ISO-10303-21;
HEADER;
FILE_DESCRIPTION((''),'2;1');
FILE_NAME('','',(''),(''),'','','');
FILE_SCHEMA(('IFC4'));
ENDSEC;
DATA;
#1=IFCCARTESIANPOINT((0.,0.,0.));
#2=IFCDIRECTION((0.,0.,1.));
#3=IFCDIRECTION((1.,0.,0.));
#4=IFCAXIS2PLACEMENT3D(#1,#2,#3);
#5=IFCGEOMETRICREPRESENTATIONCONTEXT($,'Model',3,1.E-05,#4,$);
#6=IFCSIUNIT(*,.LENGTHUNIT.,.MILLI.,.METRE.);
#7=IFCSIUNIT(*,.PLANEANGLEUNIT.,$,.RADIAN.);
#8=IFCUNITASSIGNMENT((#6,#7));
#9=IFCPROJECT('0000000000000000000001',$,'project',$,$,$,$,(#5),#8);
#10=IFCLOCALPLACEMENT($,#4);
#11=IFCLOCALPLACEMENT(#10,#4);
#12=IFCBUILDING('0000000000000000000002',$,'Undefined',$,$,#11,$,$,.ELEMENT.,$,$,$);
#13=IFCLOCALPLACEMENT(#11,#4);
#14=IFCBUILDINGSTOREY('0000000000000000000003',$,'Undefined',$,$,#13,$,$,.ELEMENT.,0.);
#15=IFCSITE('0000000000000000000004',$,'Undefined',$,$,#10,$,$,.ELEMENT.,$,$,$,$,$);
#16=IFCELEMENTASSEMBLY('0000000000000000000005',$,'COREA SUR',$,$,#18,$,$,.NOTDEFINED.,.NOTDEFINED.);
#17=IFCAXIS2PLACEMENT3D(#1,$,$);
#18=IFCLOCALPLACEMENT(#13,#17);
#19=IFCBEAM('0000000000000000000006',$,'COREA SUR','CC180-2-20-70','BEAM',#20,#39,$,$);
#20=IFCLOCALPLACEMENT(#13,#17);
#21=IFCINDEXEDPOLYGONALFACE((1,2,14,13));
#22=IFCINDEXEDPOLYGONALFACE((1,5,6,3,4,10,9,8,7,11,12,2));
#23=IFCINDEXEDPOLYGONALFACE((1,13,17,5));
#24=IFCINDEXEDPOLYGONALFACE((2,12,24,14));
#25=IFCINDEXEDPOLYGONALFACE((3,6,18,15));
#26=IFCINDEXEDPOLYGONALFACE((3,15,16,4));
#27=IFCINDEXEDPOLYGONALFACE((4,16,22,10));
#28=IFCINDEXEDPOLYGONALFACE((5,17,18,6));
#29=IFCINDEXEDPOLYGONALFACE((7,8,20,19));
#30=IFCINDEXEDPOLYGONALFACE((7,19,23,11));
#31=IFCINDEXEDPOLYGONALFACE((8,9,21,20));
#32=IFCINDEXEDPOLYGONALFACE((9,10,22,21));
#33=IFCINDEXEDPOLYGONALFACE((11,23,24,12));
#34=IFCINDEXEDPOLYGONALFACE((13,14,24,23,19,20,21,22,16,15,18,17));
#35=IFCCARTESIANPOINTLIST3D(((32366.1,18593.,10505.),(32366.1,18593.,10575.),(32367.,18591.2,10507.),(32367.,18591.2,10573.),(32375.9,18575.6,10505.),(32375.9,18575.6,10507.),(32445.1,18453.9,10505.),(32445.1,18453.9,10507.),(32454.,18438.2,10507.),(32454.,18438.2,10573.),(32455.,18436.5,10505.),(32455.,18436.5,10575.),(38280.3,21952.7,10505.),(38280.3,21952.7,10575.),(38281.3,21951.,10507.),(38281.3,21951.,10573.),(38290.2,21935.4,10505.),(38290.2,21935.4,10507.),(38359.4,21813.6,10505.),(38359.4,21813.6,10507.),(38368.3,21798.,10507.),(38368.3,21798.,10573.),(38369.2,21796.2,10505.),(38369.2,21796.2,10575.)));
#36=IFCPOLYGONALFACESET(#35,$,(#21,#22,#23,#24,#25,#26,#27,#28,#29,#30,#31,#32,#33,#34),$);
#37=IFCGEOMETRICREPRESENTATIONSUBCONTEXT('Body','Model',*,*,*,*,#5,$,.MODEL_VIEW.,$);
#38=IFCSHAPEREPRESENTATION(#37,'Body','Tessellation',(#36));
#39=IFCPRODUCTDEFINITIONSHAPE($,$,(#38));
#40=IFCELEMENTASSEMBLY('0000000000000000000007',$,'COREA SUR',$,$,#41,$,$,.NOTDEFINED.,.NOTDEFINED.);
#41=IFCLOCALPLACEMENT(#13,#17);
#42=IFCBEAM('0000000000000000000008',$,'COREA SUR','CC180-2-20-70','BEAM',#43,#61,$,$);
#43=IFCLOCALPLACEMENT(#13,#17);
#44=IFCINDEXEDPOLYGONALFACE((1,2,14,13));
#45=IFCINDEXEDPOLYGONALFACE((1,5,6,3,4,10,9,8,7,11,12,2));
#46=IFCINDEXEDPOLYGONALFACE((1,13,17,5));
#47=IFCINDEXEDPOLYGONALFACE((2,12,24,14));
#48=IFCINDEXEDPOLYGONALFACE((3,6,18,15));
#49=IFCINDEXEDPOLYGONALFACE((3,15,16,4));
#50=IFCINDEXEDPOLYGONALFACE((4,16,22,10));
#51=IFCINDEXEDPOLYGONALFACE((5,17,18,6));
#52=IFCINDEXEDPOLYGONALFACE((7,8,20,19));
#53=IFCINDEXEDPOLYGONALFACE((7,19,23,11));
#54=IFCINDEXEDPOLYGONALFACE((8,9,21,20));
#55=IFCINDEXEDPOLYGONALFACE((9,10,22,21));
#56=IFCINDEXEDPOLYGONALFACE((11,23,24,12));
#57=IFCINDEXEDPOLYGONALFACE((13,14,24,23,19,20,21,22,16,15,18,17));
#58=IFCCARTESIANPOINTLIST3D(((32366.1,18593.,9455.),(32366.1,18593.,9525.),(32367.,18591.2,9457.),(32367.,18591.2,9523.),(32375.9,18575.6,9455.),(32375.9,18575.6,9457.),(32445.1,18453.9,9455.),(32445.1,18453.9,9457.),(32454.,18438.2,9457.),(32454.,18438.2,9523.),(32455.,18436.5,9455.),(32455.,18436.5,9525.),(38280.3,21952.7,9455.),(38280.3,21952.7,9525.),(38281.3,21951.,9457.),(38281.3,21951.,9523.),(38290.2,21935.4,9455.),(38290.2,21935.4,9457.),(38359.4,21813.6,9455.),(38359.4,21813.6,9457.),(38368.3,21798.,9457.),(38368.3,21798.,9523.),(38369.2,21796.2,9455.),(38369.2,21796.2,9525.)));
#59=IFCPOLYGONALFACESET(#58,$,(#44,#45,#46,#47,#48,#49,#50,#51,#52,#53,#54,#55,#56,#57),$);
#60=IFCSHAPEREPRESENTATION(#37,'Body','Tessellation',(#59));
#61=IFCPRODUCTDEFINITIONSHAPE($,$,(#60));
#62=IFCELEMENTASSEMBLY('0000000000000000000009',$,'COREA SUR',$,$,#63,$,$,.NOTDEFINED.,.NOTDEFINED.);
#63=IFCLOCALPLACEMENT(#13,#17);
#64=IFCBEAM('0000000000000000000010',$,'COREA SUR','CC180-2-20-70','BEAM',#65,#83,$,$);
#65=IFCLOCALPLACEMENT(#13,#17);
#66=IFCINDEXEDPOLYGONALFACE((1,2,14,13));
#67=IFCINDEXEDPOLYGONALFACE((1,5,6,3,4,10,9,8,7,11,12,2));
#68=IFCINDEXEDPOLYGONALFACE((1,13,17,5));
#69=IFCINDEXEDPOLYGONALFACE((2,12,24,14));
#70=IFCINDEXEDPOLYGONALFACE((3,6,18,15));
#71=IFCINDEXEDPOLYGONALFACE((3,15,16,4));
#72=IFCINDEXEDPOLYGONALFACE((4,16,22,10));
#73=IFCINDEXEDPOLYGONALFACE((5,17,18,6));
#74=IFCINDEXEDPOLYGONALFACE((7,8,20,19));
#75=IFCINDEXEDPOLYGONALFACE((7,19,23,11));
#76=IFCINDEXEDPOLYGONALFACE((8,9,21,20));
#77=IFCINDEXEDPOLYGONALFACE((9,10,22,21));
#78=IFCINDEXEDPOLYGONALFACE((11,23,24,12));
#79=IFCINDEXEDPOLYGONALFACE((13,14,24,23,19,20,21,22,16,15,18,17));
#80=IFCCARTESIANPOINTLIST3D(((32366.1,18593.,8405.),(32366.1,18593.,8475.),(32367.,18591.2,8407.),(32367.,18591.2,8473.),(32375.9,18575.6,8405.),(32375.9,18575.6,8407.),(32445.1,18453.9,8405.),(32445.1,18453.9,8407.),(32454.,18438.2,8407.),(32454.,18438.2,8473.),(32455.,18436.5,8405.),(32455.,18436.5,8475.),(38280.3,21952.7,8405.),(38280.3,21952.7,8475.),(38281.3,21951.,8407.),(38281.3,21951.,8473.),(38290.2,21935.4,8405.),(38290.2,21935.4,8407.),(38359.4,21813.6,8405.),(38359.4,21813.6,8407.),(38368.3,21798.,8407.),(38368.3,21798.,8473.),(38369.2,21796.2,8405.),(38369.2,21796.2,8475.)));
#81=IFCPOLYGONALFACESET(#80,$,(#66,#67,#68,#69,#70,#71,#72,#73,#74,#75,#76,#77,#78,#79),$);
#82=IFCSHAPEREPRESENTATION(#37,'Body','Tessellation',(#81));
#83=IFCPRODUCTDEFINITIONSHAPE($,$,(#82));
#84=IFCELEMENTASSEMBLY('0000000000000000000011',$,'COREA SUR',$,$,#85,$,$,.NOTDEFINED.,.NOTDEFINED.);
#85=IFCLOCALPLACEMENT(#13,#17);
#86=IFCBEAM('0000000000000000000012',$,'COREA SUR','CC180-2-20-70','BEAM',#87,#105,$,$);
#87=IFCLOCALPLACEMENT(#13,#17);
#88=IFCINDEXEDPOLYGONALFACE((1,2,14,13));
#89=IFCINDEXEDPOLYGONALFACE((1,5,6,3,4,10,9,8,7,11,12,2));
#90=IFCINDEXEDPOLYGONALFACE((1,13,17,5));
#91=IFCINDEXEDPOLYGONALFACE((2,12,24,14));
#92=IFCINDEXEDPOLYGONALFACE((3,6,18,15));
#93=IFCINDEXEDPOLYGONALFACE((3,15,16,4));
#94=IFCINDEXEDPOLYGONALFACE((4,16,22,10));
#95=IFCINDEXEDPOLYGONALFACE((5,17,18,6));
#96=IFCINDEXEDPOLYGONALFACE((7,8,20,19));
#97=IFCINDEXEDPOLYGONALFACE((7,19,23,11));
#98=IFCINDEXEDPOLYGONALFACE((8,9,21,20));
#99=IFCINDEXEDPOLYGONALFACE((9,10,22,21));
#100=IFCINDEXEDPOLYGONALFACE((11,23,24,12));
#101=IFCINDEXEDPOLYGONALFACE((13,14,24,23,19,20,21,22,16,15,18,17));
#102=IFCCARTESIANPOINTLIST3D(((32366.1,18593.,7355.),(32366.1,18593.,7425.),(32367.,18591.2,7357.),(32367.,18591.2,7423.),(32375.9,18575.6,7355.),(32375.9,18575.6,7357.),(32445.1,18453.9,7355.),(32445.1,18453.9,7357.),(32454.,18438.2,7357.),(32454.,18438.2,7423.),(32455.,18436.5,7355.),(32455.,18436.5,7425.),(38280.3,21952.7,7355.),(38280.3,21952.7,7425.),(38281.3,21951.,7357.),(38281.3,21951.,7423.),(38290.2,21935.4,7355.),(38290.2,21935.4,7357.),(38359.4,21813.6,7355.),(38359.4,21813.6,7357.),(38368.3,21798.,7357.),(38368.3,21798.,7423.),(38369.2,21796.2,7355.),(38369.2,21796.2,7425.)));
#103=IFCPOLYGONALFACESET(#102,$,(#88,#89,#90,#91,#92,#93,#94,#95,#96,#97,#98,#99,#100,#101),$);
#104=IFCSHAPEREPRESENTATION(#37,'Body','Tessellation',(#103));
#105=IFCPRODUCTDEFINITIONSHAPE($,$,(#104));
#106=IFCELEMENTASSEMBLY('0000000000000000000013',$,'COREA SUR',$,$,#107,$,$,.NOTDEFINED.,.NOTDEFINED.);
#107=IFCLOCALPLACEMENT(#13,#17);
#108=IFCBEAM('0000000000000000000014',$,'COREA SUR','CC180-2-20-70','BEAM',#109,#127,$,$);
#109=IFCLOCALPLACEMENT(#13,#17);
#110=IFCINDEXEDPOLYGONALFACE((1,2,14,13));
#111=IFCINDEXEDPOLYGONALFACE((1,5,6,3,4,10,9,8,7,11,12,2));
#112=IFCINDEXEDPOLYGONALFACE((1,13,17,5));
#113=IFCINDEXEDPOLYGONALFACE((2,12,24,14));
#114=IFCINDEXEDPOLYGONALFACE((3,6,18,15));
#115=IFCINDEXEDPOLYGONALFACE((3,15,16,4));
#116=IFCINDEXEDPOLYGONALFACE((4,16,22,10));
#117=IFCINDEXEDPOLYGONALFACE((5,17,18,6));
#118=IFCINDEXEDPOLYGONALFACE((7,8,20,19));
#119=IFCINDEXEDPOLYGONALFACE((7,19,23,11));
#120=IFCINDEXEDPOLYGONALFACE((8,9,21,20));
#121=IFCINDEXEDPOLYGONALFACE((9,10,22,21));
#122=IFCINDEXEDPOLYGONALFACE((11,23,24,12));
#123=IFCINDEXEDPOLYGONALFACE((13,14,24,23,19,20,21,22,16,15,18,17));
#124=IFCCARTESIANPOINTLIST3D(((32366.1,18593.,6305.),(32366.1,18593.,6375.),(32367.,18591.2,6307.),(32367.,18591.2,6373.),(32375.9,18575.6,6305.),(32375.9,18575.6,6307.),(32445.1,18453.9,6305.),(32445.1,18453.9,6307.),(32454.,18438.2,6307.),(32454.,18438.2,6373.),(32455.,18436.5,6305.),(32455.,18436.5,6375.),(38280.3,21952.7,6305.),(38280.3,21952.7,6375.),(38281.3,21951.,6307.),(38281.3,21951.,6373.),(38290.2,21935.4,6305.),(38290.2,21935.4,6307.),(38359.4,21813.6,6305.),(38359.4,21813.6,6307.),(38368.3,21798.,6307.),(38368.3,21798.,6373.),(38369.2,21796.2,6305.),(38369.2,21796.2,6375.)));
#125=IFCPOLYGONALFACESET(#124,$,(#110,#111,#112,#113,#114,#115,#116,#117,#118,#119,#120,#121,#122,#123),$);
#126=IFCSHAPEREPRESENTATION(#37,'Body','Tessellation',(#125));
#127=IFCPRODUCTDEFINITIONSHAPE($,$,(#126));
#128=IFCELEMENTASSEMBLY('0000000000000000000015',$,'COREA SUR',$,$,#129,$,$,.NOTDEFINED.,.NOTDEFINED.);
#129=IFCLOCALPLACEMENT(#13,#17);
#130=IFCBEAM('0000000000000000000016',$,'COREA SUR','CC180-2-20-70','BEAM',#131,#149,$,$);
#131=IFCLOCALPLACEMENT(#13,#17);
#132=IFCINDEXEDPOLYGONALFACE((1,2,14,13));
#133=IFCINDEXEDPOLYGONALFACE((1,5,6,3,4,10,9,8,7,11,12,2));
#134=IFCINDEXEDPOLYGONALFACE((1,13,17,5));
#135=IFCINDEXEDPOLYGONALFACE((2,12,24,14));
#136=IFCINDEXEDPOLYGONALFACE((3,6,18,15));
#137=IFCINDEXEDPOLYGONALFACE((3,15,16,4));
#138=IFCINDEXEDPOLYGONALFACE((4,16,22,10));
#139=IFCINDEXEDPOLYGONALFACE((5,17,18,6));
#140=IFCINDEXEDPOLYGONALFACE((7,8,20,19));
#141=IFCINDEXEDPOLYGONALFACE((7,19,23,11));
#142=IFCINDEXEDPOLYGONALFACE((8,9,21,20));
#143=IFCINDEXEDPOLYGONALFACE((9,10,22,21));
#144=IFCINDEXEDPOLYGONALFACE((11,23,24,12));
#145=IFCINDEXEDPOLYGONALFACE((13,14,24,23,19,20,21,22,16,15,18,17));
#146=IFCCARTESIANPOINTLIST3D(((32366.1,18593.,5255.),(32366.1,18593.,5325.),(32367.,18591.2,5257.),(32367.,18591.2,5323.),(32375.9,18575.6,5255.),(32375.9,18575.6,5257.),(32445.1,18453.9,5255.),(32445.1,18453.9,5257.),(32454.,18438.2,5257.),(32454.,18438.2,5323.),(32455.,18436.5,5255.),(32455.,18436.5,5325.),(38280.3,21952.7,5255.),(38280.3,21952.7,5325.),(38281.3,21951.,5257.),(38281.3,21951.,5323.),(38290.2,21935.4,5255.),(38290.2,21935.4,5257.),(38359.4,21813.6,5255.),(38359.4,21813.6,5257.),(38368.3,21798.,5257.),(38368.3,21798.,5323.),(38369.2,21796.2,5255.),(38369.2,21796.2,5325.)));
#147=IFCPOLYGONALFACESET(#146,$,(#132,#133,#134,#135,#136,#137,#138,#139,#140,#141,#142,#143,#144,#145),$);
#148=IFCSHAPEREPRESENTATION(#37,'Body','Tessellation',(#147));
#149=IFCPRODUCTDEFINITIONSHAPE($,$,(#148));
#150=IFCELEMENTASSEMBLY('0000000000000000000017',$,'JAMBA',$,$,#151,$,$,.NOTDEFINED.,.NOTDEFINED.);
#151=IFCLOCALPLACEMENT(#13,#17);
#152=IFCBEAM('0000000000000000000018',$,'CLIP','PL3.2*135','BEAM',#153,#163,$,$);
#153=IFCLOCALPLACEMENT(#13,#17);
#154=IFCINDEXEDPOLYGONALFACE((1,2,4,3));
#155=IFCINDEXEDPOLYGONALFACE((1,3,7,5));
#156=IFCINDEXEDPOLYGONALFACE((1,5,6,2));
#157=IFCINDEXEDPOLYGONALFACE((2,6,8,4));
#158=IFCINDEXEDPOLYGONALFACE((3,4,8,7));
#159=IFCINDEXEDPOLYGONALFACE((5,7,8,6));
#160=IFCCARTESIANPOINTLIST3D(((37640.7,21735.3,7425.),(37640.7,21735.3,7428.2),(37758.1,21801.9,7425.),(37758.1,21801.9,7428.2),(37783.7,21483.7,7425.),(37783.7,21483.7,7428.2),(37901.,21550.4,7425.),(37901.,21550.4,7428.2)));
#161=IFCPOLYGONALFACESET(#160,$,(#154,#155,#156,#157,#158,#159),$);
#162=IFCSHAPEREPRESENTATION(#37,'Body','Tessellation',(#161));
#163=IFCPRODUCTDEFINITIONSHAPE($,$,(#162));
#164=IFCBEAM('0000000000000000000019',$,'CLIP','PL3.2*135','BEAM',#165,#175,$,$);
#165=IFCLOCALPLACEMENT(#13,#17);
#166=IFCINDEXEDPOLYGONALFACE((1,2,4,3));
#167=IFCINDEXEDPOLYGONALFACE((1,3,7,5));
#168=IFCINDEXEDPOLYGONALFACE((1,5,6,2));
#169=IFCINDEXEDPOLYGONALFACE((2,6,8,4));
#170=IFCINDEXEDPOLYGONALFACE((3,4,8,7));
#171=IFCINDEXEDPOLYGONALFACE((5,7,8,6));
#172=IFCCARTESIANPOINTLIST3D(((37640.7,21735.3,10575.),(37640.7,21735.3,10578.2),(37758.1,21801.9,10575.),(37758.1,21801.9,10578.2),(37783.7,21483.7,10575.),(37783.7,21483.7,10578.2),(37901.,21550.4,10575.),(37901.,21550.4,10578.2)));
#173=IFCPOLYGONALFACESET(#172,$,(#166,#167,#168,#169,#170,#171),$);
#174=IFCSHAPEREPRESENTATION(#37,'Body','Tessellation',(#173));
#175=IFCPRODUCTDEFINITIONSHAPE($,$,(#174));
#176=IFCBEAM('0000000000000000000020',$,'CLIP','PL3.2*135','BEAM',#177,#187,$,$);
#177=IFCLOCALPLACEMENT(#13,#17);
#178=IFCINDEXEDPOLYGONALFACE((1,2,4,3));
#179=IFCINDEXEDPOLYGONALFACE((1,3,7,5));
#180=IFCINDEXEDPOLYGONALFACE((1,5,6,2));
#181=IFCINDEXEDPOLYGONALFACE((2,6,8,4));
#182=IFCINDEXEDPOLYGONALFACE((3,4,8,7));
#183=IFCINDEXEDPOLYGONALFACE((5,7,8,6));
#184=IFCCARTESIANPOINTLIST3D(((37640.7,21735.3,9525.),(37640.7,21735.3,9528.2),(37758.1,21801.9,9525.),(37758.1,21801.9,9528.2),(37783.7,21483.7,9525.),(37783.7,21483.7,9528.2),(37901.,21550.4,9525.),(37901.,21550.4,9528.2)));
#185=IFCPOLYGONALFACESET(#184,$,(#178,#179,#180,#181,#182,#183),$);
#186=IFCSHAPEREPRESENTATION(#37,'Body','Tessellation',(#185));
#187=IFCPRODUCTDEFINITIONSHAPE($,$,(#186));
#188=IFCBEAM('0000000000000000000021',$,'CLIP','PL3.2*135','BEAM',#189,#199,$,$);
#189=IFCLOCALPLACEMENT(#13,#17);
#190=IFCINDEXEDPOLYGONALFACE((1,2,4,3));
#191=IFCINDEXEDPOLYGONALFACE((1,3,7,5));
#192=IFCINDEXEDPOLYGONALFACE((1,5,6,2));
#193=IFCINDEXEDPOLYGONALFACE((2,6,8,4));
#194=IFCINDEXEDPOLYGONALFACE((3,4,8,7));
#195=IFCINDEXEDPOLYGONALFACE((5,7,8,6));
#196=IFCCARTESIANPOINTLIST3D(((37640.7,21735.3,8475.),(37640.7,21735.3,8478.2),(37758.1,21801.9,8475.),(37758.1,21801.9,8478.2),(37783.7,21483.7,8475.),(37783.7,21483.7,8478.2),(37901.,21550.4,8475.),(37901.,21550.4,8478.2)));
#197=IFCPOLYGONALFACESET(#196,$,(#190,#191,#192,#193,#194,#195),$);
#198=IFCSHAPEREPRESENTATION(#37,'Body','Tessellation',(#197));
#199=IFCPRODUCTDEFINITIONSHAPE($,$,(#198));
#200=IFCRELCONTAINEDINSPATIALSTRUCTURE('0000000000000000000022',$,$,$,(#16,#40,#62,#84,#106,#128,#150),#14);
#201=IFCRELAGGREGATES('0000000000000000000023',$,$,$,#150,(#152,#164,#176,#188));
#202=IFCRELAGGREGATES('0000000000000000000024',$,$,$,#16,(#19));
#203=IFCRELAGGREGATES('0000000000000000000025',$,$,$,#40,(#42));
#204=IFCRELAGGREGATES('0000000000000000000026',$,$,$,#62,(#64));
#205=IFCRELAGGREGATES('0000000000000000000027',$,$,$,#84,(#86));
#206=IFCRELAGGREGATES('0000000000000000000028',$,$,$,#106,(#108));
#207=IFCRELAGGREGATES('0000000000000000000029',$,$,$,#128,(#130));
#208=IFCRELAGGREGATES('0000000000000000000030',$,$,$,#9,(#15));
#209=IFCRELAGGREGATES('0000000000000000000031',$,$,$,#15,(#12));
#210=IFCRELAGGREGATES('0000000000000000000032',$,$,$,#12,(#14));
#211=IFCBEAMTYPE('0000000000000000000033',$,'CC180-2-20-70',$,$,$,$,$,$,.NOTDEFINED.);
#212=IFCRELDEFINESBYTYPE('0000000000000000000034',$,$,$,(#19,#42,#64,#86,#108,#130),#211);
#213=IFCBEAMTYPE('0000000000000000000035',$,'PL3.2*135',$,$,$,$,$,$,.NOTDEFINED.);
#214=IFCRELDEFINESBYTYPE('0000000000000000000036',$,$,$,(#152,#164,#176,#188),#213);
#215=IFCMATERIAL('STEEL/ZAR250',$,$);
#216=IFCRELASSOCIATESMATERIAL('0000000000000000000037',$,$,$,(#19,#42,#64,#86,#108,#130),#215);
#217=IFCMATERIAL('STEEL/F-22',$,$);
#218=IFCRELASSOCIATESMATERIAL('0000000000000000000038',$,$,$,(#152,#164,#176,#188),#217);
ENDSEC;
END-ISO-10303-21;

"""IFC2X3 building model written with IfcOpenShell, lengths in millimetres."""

from ifc_helpers import new_model, si_unit, frame, origin_with_axes, origin_2d_with_axis, place, context, subcontext, project, spatial, rectangle, c_section, extrude, material, type_object, element, aggregate, save


model = new_model("IFC2X3")

# Units and contexts
model_context = context("Model", 3, precision=1e-05, world=origin_with_axes())
body_context = subcontext(model_context, "Body", "Model", "MODEL_VIEW")
ifc_project = project(units=[si_unit("LENGTHUNIT", "METRE", prefix="MILLI"), si_unit("PLANEANGLEUNIT", "RADIAN")], contexts=[model_context])

# Site, building, storey
site_placement = place(None, origin_with_axes())
site = spatial("IfcSite", under=ifc_project, at=site_placement, Name="Undefined", CompositionType="ELEMENT")
building_placement = place(site_placement, origin_with_axes())
building = spatial("IfcBuilding", under=site, at=building_placement, Name="Undefined", CompositionType="ELEMENT")
storey_placement = place(building_placement, origin_with_axes())
storey = spatial("IfcBuildingStorey", under=building, at=storey_placement, Name="Undefined", CompositionType="ELEMENT", Elevation=0.0)

# Element assemblies, beams
assembly_1_placement = place(storey_placement, origin_with_axes())
assembly_1 = element("IfcElementAssembly", 1, at=assembly_1_placement, inside=storey, Name="COREA SUR", AssemblyPlace="NOTDEFINED", PredefinedType="NOTDEFINED")
ifc_material_1 = material(Name="STEEL/ZAR250")
beam_type_1 = type_object("IfcBeamType", Name="CC180-2-20-70", PredefinedType="NOTDEFINED")
beam_1_placement = place(assembly_1_placement, frame((32410.5, 18514.7, 10540.0), z_axis=(0.493942, -0.869495, 0.0), x_axis=(0.869495, 0.493942, 0.0)))
beam_1 = element("IfcBeam", 2, at=beam_1_placement, type_object=beam_type_1, material=ifc_material_1, Name="COREA SUR", Description="CC180-2-20-70", ObjectType="BEAM", context=body_context, shape_type="SweptSolid", body=[
    extrude(c_section(Depth=180.0, Width=70.0, WallThickness=2.0, Girth=20.0, at=origin_2d_with_axis()), frame((6802.0, 0.0, 0.0), z_axis=(-1.0, 0.0, 0.0), x_axis=(0.0, -1.0, 0.0)), (0.0, 0.0, 1.0), 6802.0),
])
assembly_2_placement = place(storey_placement, origin_with_axes())
assembly_2 = element("IfcElementAssembly", 3, at=assembly_2_placement, inside=storey, Name="COREA SUR", AssemblyPlace="NOTDEFINED", PredefinedType="NOTDEFINED")
beam_2_placement = place(assembly_2_placement, frame((32410.5, 18514.7, 9490.0), z_axis=(0.493942, -0.869495, 0.0), x_axis=(0.869495, 0.493942, 0.0)))
beam_2 = element("IfcBeam", 4, at=beam_2_placement, type_object=beam_type_1, material=ifc_material_1, Name="COREA SUR", Description="CC180-2-20-70", ObjectType="BEAM", context=body_context, shape_type="SweptSolid", body=[
    extrude(c_section(Depth=180.0, Width=70.0, WallThickness=2.0, Girth=20.0, at=origin_2d_with_axis()), frame((6802.0, 0.0, 0.0), z_axis=(-1.0, 0.0, 0.0), x_axis=(0.0, -1.0, 0.0)), (0.0, 0.0, 1.0), 6802.0),
])
assembly_3_placement = place(storey_placement, origin_with_axes())
assembly_3 = element("IfcElementAssembly", 5, at=assembly_3_placement, inside=storey, Name="COREA SUR", AssemblyPlace="NOTDEFINED", PredefinedType="NOTDEFINED")
beam_3_placement = place(assembly_3_placement, frame((32410.5, 18514.7, 8440.0), z_axis=(0.493942, -0.869495, 0.0), x_axis=(0.869495, 0.493942, 0.0)))
beam_3 = element("IfcBeam", 6, at=beam_3_placement, type_object=beam_type_1, material=ifc_material_1, Name="COREA SUR", Description="CC180-2-20-70", ObjectType="BEAM", context=body_context, shape_type="SweptSolid", body=[
    extrude(c_section(Depth=180.0, Width=70.0, WallThickness=2.0, Girth=20.0, at=origin_2d_with_axis()), frame((6802.0, 0.0, 0.0), z_axis=(-1.0, 0.0, 0.0), x_axis=(0.0, -1.0, 0.0)), (0.0, 0.0, 1.0), 6802.0),
])
assembly_4_placement = place(storey_placement, origin_with_axes())
assembly_4 = element("IfcElementAssembly", 7, at=assembly_4_placement, inside=storey, Name="COREA SUR", AssemblyPlace="NOTDEFINED", PredefinedType="NOTDEFINED")
beam_4_placement = place(assembly_4_placement, frame((32410.5, 18514.7, 7390.0), z_axis=(0.493942, -0.869495, 0.0), x_axis=(0.869495, 0.493942, 0.0)))
beam_4 = element("IfcBeam", 8, at=beam_4_placement, type_object=beam_type_1, material=ifc_material_1, Name="COREA SUR", Description="CC180-2-20-70", ObjectType="BEAM", context=body_context, shape_type="SweptSolid", body=[
    extrude(c_section(Depth=180.0, Width=70.0, WallThickness=2.0, Girth=20.0, at=origin_2d_with_axis()), frame((6802.0, 0.0, 0.0), z_axis=(-1.0, 0.0, 0.0), x_axis=(0.0, -1.0, 0.0)), (0.0, 0.0, 1.0), 6802.0),
])
assembly_5_placement = place(storey_placement, origin_with_axes())
assembly_5 = element("IfcElementAssembly", 9, at=assembly_5_placement, inside=storey, Name="COREA SUR", AssemblyPlace="NOTDEFINED", PredefinedType="NOTDEFINED")
beam_5_placement = place(assembly_5_placement, frame((32410.5, 18514.7, 6340.0), z_axis=(0.493942, -0.869495, 0.0), x_axis=(0.869495, 0.493942, 0.0)))
beam_5 = element("IfcBeam", 10, at=beam_5_placement, type_object=beam_type_1, material=ifc_material_1, Name="COREA SUR", Description="CC180-2-20-70", ObjectType="BEAM", context=body_context, shape_type="SweptSolid", body=[
    extrude(c_section(Depth=180.0, Width=70.0, WallThickness=2.0, Girth=20.0, at=origin_2d_with_axis()), frame((6802.0, 0.0, 0.0), z_axis=(-1.0, 0.0, 0.0), x_axis=(0.0, -1.0, 0.0)), (0.0, 0.0, 1.0), 6802.0),
])
assembly_6_placement = place(storey_placement, origin_with_axes())
assembly_6 = element("IfcElementAssembly", 11, at=assembly_6_placement, inside=storey, Name="COREA SUR", AssemblyPlace="NOTDEFINED", PredefinedType="NOTDEFINED")
beam_6_placement = place(assembly_6_placement, frame((32410.5, 18514.7, 5290.0), z_axis=(0.493942, -0.869495, 0.0), x_axis=(0.869495, 0.493942, 0.0)))
beam_6 = element("IfcBeam", 12, at=beam_6_placement, type_object=beam_type_1, material=ifc_material_1, Name="COREA SUR", Description="CC180-2-20-70", ObjectType="BEAM", context=body_context, shape_type="SweptSolid", body=[
    extrude(c_section(Depth=180.0, Width=70.0, WallThickness=2.0, Girth=20.0, at=origin_2d_with_axis()), frame((6802.0, 0.0, 0.0), z_axis=(-1.0, 0.0, 0.0), x_axis=(0.0, -1.0, 0.0)), (0.0, 0.0, 1.0), 6802.0),
])

# Element assembly, beams
assembly_7_placement = place(storey_placement, origin_with_axes())
assembly_7 = element("IfcElementAssembly", 13, at=assembly_7_placement, inside=storey, Name="JAMBA", AssemblyPlace="NOTDEFINED", PredefinedType="NOTDEFINED")
ifc_material_2 = material(Name="STEEL/F-22")
beam_type_2 = type_object("IfcBeamType", Name="PL3.2*135", PredefinedType="NOTDEFINED")
beam_7_placement = place(assembly_7_placement, frame((37842.3, 21517.0, 7426.6), z_axis=(-0.869495, -0.493942, 0.0), x_axis=(-0.493942, 0.869495, 0.0)))
beam_7 = element("IfcBeam", 14, at=beam_7_placement, type_object=beam_type_2, material=ifc_material_2, Name="CLIP", Description="PL3.2*135", ObjectType="BEAM", context=body_context, shape_type="SweptSolid", body=[
    extrude(rectangle(XDim=3.2, YDim=135.0, at=origin_2d_with_axis()), frame((289.3, 0.0, 0.0), z_axis=(-1.0, 0.0, 0.0), x_axis=(0.0, -1.0, 0.0)), (0.0, 0.0, 1.0), 289.3),
])
beam_8_placement = place(assembly_7_placement, frame((37842.3, 21517.0, 10576.6), z_axis=(-0.869495, -0.493942, 0.0), x_axis=(-0.493942, 0.869495, 0.0)))
beam_8 = element("IfcBeam", 15, at=beam_8_placement, type_object=beam_type_2, material=ifc_material_2, Name="CLIP", Description="PL3.2*135", ObjectType="BEAM", context=body_context, shape_type="SweptSolid", body=[
    extrude(rectangle(XDim=3.2, YDim=135.0, at=origin_2d_with_axis()), frame((289.3, 0.0, 0.0), z_axis=(-1.0, 0.0, 0.0), x_axis=(0.0, -1.0, 0.0)), (0.0, 0.0, 1.0), 289.3),
])
beam_9_placement = place(assembly_7_placement, frame((37842.3, 21517.0, 9526.6), z_axis=(-0.869495, -0.493942, 0.0), x_axis=(-0.493942, 0.869495, 0.0)))
beam_9 = element("IfcBeam", 16, at=beam_9_placement, type_object=beam_type_2, material=ifc_material_2, Name="CLIP", Description="PL3.2*135", ObjectType="BEAM", context=body_context, shape_type="SweptSolid", body=[
    extrude(rectangle(XDim=3.2, YDim=135.0, at=origin_2d_with_axis()), frame((289.3, 0.0, 0.0), z_axis=(-1.0, 0.0, 0.0), x_axis=(0.0, -1.0, 0.0)), (0.0, 0.0, 1.0), 289.3),
])
beam_10_placement = place(assembly_7_placement, frame((37842.3, 21517.0, 8476.6), z_axis=(-0.869495, -0.493942, 0.0), x_axis=(-0.493942, 0.869495, 0.0)))
beam_10 = element("IfcBeam", 17, at=beam_10_placement, type_object=beam_type_2, material=ifc_material_2, Name="CLIP", Description="PL3.2*135", ObjectType="BEAM", context=body_context, shape_type="SweptSolid", body=[
    extrude(rectangle(XDim=3.2, YDim=135.0, at=origin_2d_with_axis()), frame((289.3, 0.0, 0.0), z_axis=(-1.0, 0.0, 0.0), x_axis=(0.0, -1.0, 0.0)), (0.0, 0.0, 1.0), 289.3),
])
aggregate(assembly_7, [beam_7, beam_8, beam_9, beam_10])

aggregate(assembly_1, [beam_1])

aggregate(assembly_2, [beam_2])

aggregate(assembly_3, [beam_3])

aggregate(assembly_4, [beam_4])

aggregate(assembly_5, [beam_5])

aggregate(assembly_6, [beam_6])

save(model, "model.ifc")
